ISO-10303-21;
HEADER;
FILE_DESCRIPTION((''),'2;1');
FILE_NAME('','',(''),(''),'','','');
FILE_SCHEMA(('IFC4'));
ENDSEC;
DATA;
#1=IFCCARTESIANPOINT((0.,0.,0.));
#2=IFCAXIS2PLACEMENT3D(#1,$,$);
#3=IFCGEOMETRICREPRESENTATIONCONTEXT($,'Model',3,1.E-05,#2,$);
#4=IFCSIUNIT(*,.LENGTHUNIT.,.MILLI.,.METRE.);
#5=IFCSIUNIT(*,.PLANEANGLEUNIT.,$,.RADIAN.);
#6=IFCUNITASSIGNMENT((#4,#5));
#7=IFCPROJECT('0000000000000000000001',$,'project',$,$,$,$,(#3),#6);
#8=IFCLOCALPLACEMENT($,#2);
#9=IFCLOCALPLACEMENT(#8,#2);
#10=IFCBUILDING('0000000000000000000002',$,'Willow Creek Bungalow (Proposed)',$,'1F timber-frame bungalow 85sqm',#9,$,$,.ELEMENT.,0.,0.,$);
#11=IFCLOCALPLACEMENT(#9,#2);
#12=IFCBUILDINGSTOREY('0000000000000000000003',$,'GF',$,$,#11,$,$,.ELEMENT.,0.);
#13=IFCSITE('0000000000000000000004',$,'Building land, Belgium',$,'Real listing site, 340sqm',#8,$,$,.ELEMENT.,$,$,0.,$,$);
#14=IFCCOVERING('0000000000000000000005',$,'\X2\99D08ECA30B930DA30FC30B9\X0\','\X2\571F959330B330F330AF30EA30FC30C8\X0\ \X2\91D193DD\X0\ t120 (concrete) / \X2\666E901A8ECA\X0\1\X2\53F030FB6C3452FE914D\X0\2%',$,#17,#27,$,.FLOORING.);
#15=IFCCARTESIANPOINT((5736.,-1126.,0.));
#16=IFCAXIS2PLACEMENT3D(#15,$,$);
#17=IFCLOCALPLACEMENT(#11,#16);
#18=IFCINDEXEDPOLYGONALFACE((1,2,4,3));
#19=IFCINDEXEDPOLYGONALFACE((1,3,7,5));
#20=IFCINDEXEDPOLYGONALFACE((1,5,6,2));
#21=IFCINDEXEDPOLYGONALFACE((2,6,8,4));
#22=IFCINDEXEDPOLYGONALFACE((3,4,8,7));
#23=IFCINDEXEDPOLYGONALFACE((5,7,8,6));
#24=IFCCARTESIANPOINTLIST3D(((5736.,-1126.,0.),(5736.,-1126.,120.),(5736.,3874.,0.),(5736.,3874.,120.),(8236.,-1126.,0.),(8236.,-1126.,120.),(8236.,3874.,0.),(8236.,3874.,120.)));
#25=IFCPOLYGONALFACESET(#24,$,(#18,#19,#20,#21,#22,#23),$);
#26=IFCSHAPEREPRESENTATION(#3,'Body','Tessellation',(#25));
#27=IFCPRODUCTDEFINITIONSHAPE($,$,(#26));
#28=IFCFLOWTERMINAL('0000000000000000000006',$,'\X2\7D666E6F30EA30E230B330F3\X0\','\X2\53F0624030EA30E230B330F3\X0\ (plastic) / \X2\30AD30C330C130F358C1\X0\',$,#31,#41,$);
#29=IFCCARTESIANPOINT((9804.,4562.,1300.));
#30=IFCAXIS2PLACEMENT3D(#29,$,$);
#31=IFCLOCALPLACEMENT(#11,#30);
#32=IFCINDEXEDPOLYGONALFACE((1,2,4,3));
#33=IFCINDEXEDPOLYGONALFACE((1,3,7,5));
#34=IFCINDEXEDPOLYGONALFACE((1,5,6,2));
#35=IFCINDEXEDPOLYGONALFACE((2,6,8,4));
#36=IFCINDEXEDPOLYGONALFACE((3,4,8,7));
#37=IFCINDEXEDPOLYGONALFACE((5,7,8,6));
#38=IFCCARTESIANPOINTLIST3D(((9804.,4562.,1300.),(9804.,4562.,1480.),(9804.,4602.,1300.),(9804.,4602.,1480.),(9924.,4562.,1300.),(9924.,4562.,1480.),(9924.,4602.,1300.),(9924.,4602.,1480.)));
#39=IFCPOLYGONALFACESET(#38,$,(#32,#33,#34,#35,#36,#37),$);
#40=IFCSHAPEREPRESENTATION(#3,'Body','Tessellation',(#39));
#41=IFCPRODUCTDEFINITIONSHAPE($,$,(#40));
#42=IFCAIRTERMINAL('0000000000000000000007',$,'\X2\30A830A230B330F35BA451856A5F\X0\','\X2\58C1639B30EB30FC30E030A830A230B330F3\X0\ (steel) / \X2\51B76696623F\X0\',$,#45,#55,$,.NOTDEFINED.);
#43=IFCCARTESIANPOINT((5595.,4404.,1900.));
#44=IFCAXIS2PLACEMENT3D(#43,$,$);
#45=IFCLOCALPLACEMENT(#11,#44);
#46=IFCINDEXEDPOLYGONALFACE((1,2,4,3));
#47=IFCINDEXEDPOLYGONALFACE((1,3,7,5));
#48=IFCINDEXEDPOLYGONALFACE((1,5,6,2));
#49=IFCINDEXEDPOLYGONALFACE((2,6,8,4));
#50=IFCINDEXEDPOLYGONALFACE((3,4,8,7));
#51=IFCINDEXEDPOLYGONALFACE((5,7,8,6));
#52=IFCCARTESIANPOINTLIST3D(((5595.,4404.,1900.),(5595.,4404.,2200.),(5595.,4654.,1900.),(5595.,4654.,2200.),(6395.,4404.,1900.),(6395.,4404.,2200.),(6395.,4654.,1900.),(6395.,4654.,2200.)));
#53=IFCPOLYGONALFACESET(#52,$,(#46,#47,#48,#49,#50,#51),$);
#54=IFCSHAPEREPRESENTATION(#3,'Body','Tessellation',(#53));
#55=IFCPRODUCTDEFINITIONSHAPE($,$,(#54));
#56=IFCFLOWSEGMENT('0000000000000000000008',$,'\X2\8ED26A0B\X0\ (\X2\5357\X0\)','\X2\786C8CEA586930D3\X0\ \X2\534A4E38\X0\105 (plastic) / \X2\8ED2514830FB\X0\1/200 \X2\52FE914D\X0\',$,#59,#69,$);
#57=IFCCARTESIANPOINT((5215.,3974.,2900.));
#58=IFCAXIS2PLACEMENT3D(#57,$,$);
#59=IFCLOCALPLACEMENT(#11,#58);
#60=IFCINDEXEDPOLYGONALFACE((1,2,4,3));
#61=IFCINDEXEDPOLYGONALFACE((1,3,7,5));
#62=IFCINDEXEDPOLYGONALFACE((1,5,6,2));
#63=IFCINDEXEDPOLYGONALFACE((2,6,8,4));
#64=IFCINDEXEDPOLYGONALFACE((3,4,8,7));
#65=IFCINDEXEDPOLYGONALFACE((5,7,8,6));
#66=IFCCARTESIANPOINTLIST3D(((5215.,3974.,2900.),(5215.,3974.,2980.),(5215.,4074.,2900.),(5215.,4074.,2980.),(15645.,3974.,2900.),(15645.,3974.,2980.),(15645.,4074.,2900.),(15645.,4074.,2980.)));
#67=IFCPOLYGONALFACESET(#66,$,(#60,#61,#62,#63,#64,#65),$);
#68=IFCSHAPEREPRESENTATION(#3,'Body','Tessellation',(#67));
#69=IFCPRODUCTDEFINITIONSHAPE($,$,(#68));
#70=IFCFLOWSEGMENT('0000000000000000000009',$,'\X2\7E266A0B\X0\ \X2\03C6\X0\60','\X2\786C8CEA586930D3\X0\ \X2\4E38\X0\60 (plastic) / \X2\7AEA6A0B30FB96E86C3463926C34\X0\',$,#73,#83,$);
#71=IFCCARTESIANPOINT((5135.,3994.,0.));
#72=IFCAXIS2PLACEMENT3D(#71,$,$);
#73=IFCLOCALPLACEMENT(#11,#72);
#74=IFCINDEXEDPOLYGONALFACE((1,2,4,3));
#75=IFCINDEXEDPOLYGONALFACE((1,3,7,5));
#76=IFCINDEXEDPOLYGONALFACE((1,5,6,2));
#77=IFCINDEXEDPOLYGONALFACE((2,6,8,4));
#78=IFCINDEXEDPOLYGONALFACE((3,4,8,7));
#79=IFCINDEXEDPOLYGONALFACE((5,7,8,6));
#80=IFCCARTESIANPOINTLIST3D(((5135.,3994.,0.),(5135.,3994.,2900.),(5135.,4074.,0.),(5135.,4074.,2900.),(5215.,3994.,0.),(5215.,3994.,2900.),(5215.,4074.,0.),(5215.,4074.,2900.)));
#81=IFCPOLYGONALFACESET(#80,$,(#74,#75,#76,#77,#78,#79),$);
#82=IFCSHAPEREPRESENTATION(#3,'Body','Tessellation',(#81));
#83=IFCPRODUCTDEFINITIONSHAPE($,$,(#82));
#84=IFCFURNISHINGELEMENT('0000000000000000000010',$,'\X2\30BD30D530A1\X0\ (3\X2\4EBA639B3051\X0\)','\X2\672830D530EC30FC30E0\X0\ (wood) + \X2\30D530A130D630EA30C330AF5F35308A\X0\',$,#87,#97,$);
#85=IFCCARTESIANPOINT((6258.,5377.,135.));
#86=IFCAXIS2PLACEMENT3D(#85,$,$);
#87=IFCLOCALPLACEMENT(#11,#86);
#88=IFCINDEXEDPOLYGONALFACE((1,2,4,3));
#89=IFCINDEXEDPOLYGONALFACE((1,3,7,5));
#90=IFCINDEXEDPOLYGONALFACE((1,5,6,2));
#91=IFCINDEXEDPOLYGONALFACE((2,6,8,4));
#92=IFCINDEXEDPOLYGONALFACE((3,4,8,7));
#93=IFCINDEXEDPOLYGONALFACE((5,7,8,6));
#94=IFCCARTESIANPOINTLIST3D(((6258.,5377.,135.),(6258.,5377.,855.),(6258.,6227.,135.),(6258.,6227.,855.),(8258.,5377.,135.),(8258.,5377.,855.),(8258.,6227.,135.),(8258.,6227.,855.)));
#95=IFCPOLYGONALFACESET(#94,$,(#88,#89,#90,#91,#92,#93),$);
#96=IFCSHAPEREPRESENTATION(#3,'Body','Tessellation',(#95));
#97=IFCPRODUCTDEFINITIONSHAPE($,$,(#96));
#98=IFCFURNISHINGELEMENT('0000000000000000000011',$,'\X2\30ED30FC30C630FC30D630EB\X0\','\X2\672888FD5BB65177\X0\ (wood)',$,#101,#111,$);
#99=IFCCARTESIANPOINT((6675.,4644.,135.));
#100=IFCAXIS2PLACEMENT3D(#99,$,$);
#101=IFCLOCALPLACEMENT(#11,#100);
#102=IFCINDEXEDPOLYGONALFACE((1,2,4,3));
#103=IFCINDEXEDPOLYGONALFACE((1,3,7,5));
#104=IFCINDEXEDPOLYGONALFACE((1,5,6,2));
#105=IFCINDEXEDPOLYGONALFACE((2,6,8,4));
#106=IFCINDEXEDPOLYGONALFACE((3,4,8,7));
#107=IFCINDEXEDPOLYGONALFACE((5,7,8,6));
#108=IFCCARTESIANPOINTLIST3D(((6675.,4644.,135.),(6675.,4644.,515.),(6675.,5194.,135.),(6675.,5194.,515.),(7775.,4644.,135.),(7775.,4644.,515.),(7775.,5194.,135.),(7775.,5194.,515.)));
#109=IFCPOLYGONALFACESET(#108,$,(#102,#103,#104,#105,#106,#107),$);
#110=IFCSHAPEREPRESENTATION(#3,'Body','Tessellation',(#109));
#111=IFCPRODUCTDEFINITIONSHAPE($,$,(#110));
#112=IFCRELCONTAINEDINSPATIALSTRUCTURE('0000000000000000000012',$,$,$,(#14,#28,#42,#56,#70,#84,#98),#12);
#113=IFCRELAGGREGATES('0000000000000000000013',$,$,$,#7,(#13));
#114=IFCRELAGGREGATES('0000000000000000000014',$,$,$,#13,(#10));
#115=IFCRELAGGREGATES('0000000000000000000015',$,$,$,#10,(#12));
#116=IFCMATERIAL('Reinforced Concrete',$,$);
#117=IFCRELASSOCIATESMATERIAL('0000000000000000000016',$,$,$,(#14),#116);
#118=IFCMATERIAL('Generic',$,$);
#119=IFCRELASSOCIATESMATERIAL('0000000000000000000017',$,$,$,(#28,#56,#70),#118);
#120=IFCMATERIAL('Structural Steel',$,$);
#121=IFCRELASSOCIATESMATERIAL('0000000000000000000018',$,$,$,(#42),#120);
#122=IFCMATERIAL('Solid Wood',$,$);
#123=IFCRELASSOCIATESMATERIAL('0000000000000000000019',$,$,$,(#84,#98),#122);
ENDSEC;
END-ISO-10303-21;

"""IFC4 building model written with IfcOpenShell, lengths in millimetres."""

from ifc_helpers import new_model, si_unit, frame, frame_2d, origin, place, context, project, spatial, rectangle, extrude, material, element, save


model = new_model("IFC4")

# Units and contexts
model_context = context("Model", 3, precision=1e-05, world=origin())
ifc_project = project(units=[si_unit("LENGTHUNIT", "METRE", prefix="MILLI"), si_unit("PLANEANGLEUNIT", "RADIAN")], contexts=[model_context])

# Site, building, storey
site_placement = place(None, origin())
site = spatial("IfcSite", under=ifc_project, at=site_placement, Name="Building land, Belgium", ObjectType="Real listing site, 340sqm", CompositionType="ELEMENT", RefElevation=0.0)
building_placement = place(site_placement, origin())
building = spatial("IfcBuilding", under=site, at=building_placement, Name="Willow Creek Bungalow (Proposed)", ObjectType="1F timber-frame bungalow 85sqm", CompositionType="ELEMENT", ElevationOfRefHeight=0.0, ElevationOfTerrain=0.0)
storey_placement = place(building_placement, origin())
storey = spatial("IfcBuildingStorey", under=building, at=storey_placement, Name="GF", CompositionType="ELEMENT", Elevation=0.0)

# Shared definitions
ifc_material_1 = material(Name="Solid Wood")

# Shared definitions
ifc_material_2 = material(Name="Reinforced Concrete")

# Shared definitions
ifc_material_3 = material(Name="Structural Steel")

# Covering
ifc_material_4 = material(Name="Generic")
covering_1_placement = place(storey_placement, frame((5736.0, -1126.0, 0.0)))
element("IfcCovering", 1, at=covering_1_placement, inside=storey, material=ifc_material_2, Name="駐車スペース", Description="土間コンクリート 金鏝 t120 (concrete) / 普通車1台・水勾配2%", PredefinedType="FLOORING", context=model_context, shape_type="SweptSolid", body=[
    extrude(rectangle(XDim=2500.0, YDim=5000.0, at=frame_2d((1250.0, 2500.0))), frame((5736.0, -1126.0, 0.0)), (0.0, 0.0, 1.0), 120.0),
])

# Flow terminal
flow_terminal_placement = place(storey_placement, frame((9804.0, 4562.0, 1300.0)))
element("IfcFlowTerminal", 2, at=flow_terminal_placement, inside=storey, material=ifc_material_4, Name="給湯リモコン", Description="台所リモコン (plastic) / キッチン壁", context=model_context, shape_type="SweptSolid", body=[
    extrude(rectangle(XDim=120.0, YDim=40.0, at=frame_2d((60.0, 20.0))), frame((9804.0, 4562.0, 1300.0)), (0.0, 0.0, 1.0), 180.0),
])

# Air terminal
air_terminal_placement = place(storey_placement, frame((5595.0, 4404.0, 1900.0)))
element("IfcAirTerminal", 3, at=air_terminal_placement, inside=storey, material=ifc_material_3, Name="エアコン室内機", Description="壁掛ルームエアコン (steel) / 冷暖房", PredefinedType="NOTDEFINED", context=model_context, shape_type="SweptSolid", body=[
    extrude(rectangle(XDim=800.0, YDim=250.0, at=frame_2d((400.0, 125.0))), frame((5595.0, 4404.0, 1900.0)), (0.0, 0.0, 1.0), 300.0),
])

# Flow segments
flow_segment_1_placement = place(storey_placement, frame((5215.0, 3974.0, 2900.0)))
element("IfcFlowSegment", 4, at=flow_segment_1_placement, inside=storey, material=ifc_material_4, Name="軒樋 (南)", Description="硬質塩ビ 半丸105 (plastic) / 軒先・1/200 勾配", context=model_context, shape_type="SweptSolid", body=[
    extrude(rectangle(XDim=10430.0, YDim=100.0, at=frame_2d((5215.0, 50.0))), frame((5215.0, 3974.0, 2900.0)), (0.0, 0.0, 1.0), 80.0),
])
flow_segment_2_placement = place(storey_placement, frame((5135.0, 3994.0, 0.0)))
element("IfcFlowSegment", 5, at=flow_segment_2_placement, inside=storey, material=ifc_material_4, Name="縦樋 φ60", Description="硬質塩ビ 丸60 (plastic) / 竪樋・雨水排水", context=model_context, shape_type="SweptSolid", body=[
    extrude(rectangle(XDim=80.0, YDim=80.0, at=frame_2d((40.0, 40.0))), frame((5135.0, 3994.0, 0.0)), (0.0, 0.0, 1.0), 2900.0),
])

# Furnishing elements
furnishing_1_placement = place(storey_placement, frame((6258.0, 5377.0, 135.0)))
element("IfcFurnishingElement", 6, at=furnishing_1_placement, inside=storey, material=ifc_material_1, Name="ソファ (3人掛け)", Description="木フレーム (wood) + ファブリック張り", context=model_context, shape_type="SweptSolid", body=[
    extrude(rectangle(XDim=2000.0, YDim=850.0, at=frame_2d((1000.0, 425.0))), frame((6258.0, 5377.0, 135.0)), (0.0, 0.0, 1.0), 720.0),
])
furnishing_2_placement = place(storey_placement, frame((6675.0, 4644.0, 135.0)))
element("IfcFurnishingElement", 7, at=furnishing_2_placement, inside=storey, material=ifc_material_1, Name="ローテーブル", Description="木製家具 (wood)", context=model_context, shape_type="SweptSolid", body=[
    extrude(rectangle(XDim=1100.0, YDim=550.0, at=frame_2d((550.0, 275.0))), frame((6675.0, 4644.0, 135.0)), (0.0, 0.0, 1.0), 380.0),
])

save(model, "model.ifc")
